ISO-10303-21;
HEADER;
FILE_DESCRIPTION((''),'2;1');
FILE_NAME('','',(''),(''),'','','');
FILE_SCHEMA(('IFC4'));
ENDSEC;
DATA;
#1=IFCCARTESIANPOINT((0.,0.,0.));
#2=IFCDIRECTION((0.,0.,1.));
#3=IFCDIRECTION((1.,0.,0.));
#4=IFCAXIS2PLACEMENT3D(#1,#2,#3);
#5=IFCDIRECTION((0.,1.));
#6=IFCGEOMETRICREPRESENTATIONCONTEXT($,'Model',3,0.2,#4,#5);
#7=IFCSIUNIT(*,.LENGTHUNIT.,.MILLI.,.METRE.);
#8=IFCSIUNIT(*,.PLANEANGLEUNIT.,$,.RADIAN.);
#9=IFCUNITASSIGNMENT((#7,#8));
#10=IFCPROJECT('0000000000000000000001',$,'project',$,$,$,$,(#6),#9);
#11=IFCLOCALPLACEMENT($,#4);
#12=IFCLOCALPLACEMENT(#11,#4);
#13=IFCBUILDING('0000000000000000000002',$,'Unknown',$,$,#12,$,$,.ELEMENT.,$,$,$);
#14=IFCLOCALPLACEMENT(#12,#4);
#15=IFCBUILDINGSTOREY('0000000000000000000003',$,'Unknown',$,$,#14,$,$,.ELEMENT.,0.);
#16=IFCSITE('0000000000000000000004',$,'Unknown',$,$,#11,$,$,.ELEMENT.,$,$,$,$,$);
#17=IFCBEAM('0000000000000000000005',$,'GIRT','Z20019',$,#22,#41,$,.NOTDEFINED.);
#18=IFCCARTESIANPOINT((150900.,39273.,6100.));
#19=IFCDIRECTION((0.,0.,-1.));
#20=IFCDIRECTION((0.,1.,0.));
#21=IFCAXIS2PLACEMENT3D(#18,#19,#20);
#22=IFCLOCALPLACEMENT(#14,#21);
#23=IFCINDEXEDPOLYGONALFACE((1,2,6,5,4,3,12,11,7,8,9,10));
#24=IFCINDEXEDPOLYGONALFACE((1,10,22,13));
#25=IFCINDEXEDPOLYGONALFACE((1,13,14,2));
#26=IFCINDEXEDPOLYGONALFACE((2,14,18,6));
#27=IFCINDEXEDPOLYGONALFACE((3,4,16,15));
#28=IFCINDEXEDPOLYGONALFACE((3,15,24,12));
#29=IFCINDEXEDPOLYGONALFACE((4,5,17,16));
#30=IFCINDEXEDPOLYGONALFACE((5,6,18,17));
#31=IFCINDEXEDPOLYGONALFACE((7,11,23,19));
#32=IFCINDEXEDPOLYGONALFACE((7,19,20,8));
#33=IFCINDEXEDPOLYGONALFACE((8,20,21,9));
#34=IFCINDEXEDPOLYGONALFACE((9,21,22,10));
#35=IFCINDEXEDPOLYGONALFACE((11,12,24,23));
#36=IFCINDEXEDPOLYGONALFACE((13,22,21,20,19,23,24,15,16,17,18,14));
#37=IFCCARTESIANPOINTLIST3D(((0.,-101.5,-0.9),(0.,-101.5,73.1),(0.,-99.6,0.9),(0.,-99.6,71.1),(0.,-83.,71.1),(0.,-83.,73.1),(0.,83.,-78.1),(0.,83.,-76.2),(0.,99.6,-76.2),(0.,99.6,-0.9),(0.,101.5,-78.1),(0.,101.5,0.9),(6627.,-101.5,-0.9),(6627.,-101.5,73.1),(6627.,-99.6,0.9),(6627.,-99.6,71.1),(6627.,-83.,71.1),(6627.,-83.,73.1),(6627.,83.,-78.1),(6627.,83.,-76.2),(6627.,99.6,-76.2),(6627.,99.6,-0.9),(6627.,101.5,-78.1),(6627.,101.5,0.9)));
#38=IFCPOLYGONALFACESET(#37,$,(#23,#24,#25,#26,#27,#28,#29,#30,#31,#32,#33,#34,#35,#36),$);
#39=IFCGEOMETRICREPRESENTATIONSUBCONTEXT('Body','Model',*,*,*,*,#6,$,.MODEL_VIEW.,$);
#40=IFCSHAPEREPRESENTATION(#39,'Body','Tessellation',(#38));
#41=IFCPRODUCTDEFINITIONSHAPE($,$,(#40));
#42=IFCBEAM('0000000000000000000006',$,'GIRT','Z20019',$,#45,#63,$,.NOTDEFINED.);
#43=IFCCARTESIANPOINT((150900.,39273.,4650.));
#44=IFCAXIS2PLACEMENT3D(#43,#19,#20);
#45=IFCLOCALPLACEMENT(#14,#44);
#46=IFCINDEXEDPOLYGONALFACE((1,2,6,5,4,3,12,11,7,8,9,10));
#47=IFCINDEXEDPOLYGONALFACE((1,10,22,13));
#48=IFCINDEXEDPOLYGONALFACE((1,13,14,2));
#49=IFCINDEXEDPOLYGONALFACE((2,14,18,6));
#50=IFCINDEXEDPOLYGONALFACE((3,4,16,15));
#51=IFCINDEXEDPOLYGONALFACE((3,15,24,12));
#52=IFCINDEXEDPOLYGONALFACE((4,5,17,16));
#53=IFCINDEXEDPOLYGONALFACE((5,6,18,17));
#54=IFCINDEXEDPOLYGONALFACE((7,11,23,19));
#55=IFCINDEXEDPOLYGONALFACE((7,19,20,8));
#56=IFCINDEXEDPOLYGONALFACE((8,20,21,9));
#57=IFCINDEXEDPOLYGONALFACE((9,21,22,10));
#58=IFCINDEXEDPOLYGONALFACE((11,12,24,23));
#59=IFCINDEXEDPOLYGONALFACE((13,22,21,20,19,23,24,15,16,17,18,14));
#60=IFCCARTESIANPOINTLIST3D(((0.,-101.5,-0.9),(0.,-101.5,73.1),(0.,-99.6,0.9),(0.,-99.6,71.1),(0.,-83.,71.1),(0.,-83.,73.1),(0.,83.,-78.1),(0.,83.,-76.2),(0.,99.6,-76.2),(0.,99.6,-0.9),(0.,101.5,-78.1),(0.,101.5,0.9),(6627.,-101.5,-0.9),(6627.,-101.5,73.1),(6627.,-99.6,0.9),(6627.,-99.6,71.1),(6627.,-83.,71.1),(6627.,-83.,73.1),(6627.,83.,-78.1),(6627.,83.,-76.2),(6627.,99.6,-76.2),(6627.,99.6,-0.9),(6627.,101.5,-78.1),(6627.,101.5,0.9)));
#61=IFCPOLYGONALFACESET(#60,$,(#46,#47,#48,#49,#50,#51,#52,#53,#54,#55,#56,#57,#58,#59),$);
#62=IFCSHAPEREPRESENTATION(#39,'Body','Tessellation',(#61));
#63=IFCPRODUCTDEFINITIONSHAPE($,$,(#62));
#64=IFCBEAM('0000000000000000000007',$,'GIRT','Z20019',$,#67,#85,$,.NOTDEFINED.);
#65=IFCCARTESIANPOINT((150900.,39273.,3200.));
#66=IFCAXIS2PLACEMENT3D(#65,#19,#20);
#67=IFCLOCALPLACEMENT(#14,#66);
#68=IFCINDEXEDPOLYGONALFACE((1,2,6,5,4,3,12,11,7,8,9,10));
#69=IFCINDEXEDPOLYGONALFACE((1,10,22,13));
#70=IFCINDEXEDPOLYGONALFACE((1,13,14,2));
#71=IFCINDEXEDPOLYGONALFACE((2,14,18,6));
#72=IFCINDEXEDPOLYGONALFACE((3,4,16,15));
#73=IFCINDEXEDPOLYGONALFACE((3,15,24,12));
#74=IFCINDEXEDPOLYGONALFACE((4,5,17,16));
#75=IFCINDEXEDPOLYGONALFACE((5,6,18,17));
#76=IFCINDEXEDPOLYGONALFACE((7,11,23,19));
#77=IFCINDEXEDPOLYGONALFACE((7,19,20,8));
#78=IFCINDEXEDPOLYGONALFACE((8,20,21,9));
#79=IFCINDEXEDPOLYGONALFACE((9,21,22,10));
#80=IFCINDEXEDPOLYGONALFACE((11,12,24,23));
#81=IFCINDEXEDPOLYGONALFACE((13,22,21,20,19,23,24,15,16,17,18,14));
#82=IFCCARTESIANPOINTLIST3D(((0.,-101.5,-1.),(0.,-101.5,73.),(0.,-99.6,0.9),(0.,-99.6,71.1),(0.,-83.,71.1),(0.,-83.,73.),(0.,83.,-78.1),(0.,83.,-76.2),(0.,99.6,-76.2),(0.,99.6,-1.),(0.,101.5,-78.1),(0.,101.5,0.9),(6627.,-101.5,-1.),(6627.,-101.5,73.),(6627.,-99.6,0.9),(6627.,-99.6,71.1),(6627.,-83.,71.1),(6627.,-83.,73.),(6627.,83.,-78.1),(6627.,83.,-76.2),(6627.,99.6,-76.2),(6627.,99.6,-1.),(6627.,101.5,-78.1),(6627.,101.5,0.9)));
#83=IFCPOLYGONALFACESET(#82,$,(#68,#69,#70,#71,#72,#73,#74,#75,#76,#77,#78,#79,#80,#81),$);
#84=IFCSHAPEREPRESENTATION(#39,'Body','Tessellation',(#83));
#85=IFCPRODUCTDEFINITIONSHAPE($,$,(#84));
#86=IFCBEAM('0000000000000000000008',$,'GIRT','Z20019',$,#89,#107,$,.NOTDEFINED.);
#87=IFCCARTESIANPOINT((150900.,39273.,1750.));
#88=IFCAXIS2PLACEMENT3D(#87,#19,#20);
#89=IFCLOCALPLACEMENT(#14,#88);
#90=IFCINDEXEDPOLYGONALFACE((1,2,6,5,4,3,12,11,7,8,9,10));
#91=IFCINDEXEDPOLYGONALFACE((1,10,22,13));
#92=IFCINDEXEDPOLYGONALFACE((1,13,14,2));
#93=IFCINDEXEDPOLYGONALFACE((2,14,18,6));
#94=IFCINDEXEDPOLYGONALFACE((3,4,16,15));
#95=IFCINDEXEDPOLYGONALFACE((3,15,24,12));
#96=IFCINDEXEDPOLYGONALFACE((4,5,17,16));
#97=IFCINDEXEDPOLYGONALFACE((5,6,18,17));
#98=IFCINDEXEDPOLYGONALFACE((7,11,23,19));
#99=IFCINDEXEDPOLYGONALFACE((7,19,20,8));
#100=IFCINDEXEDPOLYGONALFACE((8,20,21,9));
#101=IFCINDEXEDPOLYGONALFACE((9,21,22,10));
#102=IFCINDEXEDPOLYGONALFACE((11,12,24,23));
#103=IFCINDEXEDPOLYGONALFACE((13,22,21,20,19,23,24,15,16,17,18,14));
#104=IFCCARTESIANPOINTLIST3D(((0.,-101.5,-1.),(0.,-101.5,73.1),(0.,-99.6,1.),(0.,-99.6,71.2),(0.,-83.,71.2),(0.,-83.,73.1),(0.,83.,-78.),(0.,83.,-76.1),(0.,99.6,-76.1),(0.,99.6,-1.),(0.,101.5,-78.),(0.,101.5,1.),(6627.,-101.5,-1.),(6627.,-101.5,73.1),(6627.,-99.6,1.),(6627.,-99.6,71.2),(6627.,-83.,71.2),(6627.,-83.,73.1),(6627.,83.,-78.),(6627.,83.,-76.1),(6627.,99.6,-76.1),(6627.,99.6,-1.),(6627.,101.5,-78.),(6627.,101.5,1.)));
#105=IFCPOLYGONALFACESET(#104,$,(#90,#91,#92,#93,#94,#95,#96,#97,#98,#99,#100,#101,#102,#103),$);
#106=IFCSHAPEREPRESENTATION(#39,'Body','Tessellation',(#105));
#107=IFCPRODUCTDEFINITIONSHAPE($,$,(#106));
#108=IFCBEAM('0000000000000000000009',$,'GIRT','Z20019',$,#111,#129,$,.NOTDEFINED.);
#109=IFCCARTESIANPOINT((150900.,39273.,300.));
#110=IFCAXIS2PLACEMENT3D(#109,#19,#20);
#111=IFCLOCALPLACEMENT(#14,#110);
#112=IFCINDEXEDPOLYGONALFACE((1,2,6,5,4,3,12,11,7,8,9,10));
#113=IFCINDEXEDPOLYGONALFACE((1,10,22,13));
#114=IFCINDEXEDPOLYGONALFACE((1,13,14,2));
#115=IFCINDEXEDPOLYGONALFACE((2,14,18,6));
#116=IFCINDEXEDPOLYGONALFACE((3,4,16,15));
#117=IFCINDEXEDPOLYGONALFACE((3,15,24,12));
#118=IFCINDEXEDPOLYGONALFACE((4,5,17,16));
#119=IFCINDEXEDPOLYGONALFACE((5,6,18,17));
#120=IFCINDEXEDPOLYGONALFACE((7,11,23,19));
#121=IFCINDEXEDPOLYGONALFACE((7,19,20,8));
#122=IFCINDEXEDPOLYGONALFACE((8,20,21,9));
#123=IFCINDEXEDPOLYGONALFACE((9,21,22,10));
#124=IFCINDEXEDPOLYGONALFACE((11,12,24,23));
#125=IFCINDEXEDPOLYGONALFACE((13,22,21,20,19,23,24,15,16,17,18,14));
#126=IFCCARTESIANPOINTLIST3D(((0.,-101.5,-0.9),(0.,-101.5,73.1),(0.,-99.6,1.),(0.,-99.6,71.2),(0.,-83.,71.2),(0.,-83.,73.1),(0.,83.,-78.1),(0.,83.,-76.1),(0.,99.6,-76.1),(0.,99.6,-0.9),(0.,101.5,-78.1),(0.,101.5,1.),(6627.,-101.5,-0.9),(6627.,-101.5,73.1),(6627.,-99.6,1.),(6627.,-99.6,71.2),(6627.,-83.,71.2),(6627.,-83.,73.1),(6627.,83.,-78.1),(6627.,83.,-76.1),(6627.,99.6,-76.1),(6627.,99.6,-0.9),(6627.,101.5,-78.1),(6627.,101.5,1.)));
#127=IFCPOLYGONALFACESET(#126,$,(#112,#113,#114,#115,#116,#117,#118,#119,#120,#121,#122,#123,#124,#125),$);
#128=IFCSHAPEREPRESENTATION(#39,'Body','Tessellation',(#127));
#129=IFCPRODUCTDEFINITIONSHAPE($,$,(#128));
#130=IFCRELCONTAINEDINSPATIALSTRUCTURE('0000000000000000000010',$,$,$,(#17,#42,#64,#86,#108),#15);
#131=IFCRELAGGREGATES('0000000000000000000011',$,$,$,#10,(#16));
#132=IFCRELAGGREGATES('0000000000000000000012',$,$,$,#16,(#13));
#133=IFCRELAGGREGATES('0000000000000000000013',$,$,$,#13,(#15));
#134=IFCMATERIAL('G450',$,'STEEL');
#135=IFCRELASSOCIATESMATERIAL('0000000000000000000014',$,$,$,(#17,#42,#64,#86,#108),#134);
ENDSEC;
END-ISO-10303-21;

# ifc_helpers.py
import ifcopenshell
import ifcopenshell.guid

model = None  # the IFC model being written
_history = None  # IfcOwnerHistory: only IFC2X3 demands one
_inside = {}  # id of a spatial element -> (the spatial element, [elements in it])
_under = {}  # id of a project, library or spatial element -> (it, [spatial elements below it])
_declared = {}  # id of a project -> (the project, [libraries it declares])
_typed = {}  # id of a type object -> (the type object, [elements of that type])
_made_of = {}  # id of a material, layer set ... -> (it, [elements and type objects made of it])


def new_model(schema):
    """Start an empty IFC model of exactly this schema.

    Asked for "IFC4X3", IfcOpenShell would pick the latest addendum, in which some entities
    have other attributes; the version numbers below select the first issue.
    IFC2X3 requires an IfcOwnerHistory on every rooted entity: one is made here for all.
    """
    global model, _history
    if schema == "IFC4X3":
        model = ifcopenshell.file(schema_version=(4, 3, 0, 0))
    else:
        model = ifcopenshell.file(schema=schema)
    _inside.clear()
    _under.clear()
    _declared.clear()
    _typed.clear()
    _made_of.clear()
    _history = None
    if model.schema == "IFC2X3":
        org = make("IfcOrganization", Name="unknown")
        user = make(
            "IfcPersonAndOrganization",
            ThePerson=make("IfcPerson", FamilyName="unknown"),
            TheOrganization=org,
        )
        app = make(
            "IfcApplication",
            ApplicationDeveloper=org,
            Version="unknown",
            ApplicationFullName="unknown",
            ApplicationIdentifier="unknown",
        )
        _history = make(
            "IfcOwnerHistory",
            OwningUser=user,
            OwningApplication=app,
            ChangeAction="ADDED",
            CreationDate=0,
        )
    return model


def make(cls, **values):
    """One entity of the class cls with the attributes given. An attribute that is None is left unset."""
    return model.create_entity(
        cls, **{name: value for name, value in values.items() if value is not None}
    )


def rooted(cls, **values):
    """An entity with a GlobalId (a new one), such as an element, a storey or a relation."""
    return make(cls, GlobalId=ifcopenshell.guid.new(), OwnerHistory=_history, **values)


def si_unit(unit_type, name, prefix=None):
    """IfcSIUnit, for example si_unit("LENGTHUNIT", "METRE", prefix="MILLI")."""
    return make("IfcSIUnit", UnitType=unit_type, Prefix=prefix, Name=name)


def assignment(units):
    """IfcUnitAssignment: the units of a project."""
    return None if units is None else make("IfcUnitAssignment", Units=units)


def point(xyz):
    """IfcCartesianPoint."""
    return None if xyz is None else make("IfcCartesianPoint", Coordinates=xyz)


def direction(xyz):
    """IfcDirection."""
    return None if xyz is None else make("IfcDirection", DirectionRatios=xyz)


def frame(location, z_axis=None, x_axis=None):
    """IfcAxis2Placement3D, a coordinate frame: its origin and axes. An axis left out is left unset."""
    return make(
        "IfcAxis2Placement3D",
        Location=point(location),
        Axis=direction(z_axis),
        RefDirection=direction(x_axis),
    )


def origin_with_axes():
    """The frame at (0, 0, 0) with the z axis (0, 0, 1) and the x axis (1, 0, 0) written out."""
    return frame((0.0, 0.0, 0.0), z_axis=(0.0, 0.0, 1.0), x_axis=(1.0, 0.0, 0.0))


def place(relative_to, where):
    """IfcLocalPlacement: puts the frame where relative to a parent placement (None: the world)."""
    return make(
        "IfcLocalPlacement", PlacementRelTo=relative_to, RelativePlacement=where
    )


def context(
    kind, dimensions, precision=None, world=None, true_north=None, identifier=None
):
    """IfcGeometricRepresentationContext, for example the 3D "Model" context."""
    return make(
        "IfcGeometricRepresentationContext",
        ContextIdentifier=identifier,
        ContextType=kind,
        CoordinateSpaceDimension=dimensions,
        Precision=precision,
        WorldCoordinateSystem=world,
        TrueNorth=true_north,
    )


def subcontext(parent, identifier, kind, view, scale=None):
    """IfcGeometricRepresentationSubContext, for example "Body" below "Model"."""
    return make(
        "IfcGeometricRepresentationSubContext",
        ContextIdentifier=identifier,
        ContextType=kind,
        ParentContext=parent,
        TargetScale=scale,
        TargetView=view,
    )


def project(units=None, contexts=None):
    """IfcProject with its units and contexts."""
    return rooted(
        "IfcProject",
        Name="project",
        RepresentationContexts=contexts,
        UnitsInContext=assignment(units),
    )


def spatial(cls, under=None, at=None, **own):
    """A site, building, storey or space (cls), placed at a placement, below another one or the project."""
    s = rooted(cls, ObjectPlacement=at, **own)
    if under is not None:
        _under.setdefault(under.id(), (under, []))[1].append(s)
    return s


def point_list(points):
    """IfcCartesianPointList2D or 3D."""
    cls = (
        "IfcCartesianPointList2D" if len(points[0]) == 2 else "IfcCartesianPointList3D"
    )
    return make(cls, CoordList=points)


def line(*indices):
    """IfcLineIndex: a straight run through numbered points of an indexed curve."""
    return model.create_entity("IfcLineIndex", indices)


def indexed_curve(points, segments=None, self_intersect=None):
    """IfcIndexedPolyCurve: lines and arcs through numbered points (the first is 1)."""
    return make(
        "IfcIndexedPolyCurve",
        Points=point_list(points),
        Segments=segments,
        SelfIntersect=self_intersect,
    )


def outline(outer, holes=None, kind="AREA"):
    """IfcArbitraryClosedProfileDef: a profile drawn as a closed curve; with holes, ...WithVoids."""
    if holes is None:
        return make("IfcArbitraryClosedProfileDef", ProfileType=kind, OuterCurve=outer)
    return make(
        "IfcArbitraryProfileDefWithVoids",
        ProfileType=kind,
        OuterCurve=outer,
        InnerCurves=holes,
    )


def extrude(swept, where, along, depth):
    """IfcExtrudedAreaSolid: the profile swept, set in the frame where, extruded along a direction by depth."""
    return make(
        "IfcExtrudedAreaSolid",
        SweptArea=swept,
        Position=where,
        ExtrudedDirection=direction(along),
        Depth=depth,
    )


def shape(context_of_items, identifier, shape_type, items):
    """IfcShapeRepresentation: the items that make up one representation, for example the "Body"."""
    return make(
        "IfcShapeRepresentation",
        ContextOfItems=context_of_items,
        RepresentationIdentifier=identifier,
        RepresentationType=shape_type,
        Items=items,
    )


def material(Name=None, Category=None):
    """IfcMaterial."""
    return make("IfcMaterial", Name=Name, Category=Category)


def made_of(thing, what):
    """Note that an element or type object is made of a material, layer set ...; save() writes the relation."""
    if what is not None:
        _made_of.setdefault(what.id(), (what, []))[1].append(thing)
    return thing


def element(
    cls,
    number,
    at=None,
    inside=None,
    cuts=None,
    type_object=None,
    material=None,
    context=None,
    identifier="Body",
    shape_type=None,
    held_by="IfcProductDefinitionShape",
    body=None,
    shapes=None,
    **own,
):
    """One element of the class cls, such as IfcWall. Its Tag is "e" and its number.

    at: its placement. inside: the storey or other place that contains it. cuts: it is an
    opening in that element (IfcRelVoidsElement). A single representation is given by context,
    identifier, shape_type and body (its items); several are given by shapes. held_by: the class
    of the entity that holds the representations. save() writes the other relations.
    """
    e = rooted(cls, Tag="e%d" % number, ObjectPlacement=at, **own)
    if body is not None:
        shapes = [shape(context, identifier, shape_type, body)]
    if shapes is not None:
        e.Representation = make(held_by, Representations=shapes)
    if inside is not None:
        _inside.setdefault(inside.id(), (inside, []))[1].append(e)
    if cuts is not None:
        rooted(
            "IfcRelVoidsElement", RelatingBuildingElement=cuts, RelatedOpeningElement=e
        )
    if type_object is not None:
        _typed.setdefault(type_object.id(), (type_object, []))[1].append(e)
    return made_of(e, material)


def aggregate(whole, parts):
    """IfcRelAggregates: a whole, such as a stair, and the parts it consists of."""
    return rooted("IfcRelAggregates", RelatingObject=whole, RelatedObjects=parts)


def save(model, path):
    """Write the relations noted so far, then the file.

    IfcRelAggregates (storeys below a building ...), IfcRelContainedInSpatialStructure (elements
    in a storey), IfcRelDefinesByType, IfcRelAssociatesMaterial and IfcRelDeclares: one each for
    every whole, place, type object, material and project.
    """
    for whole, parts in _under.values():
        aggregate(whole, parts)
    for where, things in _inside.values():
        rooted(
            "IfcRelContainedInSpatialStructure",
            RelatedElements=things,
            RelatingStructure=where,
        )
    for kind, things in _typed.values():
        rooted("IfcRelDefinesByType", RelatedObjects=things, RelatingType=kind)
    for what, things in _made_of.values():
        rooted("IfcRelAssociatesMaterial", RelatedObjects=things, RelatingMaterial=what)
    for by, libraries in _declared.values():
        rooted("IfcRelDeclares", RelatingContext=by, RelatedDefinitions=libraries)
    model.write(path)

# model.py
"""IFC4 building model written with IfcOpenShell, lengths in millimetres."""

from ifc_helpers import new_model, si_unit, direction, frame, origin_with_axes, place, context, subcontext, project, spatial, line, indexed_curve, outline, extrude, material, element, save


model = new_model("IFC4")

# Units and contexts
model_context = context("Model", 3, precision=0.2, world=origin_with_axes(), true_north=direction((0.0, 1.0)))
body_context = subcontext(model_context, "Body", "Model", "MODEL_VIEW")
ifc_project = project(units=[si_unit("LENGTHUNIT", "METRE", prefix="MILLI"), si_unit("PLANEANGLEUNIT", "RADIAN")], contexts=[model_context])

# Site, building, storey
site_placement = place(None, origin_with_axes())
site = spatial("IfcSite", under=ifc_project, at=site_placement, Name="Unknown", CompositionType="ELEMENT")
building_placement = place(site_placement, origin_with_axes())
building = spatial("IfcBuilding", under=site, at=building_placement, Name="Unknown", CompositionType="ELEMENT")
storey_placement = place(building_placement, origin_with_axes())
storey = spatial("IfcBuildingStorey", under=building, at=storey_placement, Name="Unknown", CompositionType="ELEMENT", Elevation=0.0)

# Shared definitions
ifc_material_1 = material(Name="G450", Category="STEEL")

# Beams
for number, where, z_axis, x_axis, name in (
    (1, (150900.0, 39273.0, 6100.0), (0.0, 0.0, -1.0), (0.0, 1.0, 0.0), "GIRT"),
    (2, (150900.0, 39273.0, 4650.0), (0.0, 0.0, -1.0), (0.0, 1.0, 0.0), "GIRT"),
    (3, (150900.0, 39273.0, 3200.0), (0.0, 0.0, -1.0), (0.0, 1.0, 0.0), "GIRT"),
    (4, (150900.0, 39273.0, 1750.0), (0.0, 0.0, -1.0), (0.0, 1.0, 0.0), "GIRT"),
    (5, (150900.0, 39273.0, 300.0), (0.0, 0.0, -1.0), (0.0, 1.0, 0.0), "GIRT"),
):
    element("IfcBeam", number, at=place(storey_placement, frame(where, z_axis=z_axis, x_axis=x_axis)), inside=storey, material=ifc_material_1, Name=name, Description="Z20019", PredefinedType="NOTDEFINED", context=body_context, shape_type="SolidModel", body=[
        extrude(outline(indexed_curve([(73.0, -101.5), (73.0, -83.0), (71.2, -83.0), (71.2, -99.6), (0.9, -99.6), (0.9, 101.5), (-78.0, 101.5), (-78.0, 83.0), (-76.2, 83.0), (-76.2, 99.6), (-0.9, 99.6), (-0.9, -101.5)], segments=[line(1, 2, 3, 4, 5, 6, 7, 8, 9, 10, 11, 12, 1)])), frame((0.0, 0.0, 0.0), z_axis=(-1.0, 0.0, 0.0), x_axis=(0.0, 0.0, 1.0)), (0.0, 0.0, -1.0), 6627.0),
    ])

save(model, "model.ifc")
